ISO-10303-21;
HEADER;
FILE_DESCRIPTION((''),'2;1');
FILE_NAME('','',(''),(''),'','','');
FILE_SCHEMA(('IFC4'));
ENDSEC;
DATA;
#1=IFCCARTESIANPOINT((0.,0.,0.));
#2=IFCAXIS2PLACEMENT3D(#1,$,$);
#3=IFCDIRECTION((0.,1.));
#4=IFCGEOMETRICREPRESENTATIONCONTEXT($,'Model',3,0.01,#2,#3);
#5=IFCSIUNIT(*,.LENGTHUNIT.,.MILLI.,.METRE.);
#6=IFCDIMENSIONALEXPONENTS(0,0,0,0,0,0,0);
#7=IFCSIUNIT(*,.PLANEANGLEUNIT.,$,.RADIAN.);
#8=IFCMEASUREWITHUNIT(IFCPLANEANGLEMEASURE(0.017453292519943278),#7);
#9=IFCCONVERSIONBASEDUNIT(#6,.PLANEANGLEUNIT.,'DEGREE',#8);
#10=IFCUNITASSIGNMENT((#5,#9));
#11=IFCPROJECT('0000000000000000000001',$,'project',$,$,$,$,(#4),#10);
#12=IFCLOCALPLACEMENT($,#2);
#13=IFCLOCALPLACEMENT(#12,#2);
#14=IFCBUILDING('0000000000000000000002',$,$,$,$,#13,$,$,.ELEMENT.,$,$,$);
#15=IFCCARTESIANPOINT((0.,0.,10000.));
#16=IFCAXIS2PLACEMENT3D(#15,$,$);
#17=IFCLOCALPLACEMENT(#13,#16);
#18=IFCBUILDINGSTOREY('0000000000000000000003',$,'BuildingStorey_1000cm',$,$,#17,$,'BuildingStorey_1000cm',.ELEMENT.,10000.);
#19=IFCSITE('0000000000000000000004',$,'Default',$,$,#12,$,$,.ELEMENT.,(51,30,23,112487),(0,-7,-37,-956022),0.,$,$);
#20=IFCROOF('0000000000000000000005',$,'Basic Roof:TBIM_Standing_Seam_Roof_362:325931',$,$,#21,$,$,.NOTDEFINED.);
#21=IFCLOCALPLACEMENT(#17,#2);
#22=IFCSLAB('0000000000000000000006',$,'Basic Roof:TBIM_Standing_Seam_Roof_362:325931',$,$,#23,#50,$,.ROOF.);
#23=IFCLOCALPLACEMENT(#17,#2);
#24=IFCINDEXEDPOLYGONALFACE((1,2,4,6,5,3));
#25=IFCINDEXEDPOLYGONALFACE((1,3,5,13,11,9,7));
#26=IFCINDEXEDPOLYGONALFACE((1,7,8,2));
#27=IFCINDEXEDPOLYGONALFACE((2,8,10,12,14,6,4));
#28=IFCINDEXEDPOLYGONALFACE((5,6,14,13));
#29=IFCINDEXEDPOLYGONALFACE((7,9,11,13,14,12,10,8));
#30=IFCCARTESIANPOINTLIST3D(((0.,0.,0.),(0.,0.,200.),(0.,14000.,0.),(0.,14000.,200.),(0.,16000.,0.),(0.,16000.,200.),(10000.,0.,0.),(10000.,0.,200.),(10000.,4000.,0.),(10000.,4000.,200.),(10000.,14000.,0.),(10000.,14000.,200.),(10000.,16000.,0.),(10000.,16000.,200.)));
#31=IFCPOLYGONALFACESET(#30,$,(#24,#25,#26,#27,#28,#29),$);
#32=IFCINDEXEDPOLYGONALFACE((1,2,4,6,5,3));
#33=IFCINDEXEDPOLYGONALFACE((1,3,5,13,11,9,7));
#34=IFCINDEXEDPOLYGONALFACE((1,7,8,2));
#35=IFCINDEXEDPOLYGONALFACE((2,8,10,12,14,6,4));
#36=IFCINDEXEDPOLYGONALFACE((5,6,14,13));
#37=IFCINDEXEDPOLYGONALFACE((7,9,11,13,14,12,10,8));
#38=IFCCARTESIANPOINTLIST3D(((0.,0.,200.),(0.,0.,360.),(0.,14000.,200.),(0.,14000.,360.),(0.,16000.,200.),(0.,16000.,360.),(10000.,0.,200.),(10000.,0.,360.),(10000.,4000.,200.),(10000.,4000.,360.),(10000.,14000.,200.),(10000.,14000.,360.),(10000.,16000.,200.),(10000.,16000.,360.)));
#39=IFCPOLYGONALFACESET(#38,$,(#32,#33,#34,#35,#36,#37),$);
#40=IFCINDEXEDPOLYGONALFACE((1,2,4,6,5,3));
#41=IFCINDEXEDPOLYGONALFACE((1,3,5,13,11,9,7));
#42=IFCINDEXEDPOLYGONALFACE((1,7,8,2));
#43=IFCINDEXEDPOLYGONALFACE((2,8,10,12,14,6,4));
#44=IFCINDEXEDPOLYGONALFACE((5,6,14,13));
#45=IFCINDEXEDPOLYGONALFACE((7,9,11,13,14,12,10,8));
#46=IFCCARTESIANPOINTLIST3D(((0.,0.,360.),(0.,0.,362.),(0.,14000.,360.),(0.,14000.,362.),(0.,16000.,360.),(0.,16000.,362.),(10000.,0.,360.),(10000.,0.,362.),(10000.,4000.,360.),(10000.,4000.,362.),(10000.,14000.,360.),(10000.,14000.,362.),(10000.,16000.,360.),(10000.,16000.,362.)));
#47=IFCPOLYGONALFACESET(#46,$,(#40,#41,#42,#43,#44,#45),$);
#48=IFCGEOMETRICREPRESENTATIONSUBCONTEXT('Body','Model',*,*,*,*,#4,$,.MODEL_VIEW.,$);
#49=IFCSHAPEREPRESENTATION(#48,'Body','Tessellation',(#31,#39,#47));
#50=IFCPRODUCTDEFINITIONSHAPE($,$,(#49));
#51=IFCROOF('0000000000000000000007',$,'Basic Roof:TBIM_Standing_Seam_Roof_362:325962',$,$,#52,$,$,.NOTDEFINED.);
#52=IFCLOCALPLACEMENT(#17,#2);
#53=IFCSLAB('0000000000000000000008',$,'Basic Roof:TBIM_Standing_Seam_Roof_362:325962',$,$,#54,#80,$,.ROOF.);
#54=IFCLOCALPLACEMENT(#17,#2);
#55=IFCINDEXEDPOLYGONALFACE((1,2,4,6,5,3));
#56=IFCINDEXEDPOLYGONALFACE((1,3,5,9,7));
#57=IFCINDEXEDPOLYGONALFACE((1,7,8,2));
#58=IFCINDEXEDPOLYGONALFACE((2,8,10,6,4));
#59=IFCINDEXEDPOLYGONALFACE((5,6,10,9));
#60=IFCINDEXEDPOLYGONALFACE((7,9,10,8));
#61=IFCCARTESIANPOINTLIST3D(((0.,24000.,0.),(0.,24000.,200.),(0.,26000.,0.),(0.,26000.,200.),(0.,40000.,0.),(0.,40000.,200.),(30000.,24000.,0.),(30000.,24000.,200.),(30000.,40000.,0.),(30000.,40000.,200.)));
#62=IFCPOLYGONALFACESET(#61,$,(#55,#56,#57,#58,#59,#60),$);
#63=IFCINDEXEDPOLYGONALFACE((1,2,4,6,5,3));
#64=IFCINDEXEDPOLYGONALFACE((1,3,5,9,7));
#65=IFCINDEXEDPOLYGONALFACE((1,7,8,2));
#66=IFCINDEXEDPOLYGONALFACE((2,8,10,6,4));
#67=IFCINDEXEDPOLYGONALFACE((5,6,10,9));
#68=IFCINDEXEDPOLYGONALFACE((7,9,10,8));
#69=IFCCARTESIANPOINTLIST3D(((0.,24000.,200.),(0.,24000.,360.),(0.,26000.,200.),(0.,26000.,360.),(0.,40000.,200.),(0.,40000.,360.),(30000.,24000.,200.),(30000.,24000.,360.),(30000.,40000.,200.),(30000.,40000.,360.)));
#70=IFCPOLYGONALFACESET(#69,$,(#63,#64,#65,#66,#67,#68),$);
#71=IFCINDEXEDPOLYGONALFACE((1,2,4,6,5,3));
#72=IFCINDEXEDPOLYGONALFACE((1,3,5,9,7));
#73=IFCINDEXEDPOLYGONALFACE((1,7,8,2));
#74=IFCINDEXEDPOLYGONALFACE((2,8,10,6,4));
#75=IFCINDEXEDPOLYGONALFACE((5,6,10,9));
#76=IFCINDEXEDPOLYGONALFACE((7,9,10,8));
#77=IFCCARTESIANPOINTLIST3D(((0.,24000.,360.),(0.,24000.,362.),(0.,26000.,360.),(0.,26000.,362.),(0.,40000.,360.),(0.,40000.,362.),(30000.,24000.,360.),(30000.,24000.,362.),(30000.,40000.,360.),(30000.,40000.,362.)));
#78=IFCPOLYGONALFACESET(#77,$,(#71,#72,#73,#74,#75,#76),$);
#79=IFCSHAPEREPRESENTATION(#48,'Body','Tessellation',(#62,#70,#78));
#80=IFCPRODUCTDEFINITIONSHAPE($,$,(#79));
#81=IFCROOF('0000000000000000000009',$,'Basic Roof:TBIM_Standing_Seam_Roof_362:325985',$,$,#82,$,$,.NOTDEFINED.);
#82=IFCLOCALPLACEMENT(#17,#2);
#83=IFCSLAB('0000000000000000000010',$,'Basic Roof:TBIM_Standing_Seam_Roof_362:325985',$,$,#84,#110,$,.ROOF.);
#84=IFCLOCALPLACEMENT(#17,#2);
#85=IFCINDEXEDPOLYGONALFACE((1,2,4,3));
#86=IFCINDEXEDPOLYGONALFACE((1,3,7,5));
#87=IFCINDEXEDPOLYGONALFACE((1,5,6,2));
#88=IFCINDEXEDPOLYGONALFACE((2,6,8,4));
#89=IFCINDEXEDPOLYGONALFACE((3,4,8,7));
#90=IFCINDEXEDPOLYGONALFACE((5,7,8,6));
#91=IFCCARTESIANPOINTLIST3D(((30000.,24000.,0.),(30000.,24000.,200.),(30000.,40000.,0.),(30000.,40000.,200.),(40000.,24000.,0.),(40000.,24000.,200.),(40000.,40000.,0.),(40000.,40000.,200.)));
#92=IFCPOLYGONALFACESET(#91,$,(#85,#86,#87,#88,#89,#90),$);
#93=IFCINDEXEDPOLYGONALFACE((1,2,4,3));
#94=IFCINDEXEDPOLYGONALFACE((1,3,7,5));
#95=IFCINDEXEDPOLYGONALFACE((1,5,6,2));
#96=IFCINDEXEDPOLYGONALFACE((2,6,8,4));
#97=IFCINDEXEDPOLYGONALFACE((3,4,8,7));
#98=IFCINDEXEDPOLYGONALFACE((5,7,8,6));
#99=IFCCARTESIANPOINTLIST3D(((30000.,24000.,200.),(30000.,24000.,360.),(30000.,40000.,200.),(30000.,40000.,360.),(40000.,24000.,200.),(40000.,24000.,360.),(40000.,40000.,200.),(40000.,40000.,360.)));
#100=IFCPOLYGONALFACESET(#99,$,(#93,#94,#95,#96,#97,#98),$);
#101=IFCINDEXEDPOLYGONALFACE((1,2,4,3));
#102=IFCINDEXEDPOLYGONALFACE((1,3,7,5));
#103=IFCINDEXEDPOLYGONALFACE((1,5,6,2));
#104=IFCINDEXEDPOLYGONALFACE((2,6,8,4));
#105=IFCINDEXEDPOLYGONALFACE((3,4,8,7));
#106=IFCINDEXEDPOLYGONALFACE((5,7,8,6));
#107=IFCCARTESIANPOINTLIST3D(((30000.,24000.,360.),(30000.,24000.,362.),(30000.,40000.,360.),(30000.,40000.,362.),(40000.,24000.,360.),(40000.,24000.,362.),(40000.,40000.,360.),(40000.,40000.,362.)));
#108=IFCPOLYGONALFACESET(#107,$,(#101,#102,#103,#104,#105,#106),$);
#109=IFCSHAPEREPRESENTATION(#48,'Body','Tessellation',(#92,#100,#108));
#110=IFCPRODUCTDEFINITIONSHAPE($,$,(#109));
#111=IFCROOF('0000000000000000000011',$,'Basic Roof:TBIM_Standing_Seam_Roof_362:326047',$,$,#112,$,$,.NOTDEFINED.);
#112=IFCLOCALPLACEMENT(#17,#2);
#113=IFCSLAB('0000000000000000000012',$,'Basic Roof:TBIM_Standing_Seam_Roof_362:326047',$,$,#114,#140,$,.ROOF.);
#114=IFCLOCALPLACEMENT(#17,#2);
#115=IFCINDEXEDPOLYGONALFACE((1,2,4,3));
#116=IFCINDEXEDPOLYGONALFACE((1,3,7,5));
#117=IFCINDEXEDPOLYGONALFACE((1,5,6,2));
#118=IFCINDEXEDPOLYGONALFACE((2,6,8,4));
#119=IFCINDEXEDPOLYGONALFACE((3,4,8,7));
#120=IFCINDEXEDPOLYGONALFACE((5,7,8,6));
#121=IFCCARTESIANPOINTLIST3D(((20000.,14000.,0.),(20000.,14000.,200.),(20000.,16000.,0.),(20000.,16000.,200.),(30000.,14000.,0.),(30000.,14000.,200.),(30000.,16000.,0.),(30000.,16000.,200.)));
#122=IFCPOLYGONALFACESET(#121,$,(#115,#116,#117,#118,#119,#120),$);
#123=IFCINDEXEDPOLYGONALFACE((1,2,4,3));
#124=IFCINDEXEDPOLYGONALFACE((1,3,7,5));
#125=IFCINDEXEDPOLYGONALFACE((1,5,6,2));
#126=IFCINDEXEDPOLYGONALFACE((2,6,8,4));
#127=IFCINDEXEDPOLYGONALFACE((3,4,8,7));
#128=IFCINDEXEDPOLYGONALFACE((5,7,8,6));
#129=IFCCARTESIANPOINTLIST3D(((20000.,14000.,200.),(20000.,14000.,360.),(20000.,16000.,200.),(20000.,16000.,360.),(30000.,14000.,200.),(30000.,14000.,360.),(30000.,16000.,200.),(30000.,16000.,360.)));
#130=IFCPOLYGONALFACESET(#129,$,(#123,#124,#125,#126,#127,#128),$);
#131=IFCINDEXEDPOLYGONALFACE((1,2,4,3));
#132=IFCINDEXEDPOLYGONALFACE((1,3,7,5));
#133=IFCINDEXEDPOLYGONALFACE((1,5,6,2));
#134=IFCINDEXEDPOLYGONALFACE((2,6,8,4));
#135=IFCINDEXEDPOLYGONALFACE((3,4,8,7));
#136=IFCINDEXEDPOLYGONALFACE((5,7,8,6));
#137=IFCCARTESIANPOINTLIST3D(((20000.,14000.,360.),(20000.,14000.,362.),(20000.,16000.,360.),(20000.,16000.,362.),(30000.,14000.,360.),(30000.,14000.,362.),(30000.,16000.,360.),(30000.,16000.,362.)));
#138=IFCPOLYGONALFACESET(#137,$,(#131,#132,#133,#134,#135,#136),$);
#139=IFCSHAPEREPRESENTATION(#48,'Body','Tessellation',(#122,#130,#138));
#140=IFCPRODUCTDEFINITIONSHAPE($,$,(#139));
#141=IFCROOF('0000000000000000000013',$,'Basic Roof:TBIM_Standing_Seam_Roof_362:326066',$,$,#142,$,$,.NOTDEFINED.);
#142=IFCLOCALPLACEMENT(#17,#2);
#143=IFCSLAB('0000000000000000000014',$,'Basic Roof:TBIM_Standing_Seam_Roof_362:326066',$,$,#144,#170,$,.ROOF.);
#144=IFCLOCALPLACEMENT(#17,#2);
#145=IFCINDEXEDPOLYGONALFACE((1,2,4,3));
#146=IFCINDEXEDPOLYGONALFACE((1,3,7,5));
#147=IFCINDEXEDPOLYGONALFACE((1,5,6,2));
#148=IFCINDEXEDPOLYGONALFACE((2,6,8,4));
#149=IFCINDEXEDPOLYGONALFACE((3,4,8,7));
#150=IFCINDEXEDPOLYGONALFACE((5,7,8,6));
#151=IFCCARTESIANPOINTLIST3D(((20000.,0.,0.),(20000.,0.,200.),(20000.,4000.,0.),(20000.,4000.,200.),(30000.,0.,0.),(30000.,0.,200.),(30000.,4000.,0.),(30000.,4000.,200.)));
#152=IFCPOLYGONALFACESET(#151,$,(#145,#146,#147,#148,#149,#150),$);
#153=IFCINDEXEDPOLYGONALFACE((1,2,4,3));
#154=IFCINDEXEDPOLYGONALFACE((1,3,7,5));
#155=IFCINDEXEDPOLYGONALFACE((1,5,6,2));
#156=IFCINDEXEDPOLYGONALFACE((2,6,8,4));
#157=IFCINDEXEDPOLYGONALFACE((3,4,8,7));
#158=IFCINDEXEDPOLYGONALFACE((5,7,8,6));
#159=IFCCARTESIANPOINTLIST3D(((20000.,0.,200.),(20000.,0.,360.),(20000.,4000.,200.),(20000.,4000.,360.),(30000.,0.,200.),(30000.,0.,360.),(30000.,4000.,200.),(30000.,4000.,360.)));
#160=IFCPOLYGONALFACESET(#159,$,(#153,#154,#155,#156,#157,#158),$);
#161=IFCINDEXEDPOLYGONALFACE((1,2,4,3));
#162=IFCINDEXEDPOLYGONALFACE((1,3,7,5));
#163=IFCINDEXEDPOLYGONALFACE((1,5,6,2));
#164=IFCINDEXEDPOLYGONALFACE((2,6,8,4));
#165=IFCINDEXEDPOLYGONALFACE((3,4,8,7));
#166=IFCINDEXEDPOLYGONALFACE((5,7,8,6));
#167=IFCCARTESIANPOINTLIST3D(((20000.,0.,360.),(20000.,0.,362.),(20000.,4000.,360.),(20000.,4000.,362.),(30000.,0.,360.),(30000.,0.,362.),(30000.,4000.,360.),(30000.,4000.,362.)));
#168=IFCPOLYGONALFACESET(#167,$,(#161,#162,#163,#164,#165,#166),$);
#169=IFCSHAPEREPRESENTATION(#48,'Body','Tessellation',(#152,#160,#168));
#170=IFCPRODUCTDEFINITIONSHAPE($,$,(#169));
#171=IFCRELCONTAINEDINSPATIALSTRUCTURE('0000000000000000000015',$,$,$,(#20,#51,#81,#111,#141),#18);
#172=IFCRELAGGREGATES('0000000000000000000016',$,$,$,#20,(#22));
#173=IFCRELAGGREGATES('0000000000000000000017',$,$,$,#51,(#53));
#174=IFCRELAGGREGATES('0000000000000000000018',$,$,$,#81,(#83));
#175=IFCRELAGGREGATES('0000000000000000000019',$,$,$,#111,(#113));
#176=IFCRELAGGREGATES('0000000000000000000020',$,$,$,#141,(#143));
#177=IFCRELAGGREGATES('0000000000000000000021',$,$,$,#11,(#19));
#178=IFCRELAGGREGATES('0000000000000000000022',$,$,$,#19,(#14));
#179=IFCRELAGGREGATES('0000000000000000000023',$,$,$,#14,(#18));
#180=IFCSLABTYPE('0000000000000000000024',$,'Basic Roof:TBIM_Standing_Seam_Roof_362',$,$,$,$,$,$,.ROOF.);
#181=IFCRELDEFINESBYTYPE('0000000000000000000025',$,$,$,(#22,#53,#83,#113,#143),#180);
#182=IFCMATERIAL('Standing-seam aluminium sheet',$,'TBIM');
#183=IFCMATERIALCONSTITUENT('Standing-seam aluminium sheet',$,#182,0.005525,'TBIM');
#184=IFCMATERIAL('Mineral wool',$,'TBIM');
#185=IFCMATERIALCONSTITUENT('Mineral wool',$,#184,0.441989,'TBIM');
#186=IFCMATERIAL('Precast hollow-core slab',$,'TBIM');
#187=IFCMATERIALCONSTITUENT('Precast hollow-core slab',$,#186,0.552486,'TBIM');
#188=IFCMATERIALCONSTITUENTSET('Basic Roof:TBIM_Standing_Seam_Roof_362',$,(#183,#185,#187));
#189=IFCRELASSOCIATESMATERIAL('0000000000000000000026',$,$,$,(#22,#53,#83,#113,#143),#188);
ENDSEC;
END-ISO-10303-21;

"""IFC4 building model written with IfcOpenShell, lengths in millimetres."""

from ifc_helpers import new_model, entity, si_unit, converted_unit, direction, frame, origin, place, context, subcontext, project, spatial, indexed_curve, outline, extrude, material, constituent, constituent_set, type_object, element, aggregate, save


model = new_model("IFC4")

# Units and contexts
model_context = context("Model", 3, precision=0.01, world=origin(), true_north=direction((0.0, 1.0)))
body_context = subcontext(model_context, "Body", "Model", "MODEL_VIEW")
ifc_project = project(units=[si_unit("LENGTHUNIT", "METRE", prefix="MILLI"), converted_unit("PLANEANGLEUNIT", "DEGREE", entity("IfcPlaneAngleMeasure", 0.017453292519943278), si_unit("PLANEANGLEUNIT", "RADIAN"), dimensions=[0, 0, 0, 0, 0, 0, 0])], contexts=[model_context])

# Site, building, storey
site_placement = place(None, origin())
site = spatial("IfcSite", under=ifc_project, at=site_placement, Name="Default", CompositionType="ELEMENT", RefLatitude=(51, 30, 23, 112487), RefLongitude=(0, -7, -37, -956022), RefElevation=0.0)
building_placement = place(site_placement, origin())
building = spatial("IfcBuilding", under=site, at=building_placement, CompositionType="ELEMENT")
storey_placement = place(building_placement, frame((0.0, 0.0, 10000.0)))
storey = spatial("IfcBuildingStorey", under=building, at=storey_placement, Name="BuildingStorey_1000cm", LongName="BuildingStorey_1000cm", CompositionType="ELEMENT", Elevation=10000.0)

# Shared definitions
ifc_material_1 = material(Name="Precast hollow-core slab", Category="TBIM")

# Roofs, slabs
ifc_material_2 = material(Name="Standing-seam aluminium sheet", Category="TBIM")
ifc_constituent_1 = constituent(ifc_material_2, Name="Standing-seam aluminium sheet", Category="TBIM", fraction=0.005525)
ifc_material_3 = material(Name="Mineral wool", Category="TBIM")
ifc_constituent_2 = constituent(ifc_material_3, Name="Mineral wool", Category="TBIM", fraction=0.441989)
ifc_constituent_3 = constituent(ifc_material_1, Name="Precast hollow-core slab", Category="TBIM", fraction=0.552486)
ifc_constituent_set_1 = constituent_set(constituents=[ifc_constituent_1, ifc_constituent_2, ifc_constituent_3], Name="Basic Roof:TBIM_Standing_Seam_Roof_362")
slab_type_1 = type_object("IfcSlabType", Name="Basic Roof:TBIM_Standing_Seam_Roof_362", PredefinedType="ROOF")
roof_1_placement = place(storey_placement, origin())
roof_1 = element("IfcRoof", 1, at=roof_1_placement, inside=storey, Name="Basic Roof:TBIM_Standing_Seam_Roof_362:325931", PredefinedType="NOTDEFINED")
slab_1_placement = place(roof_1_placement, origin())
slab_1 = element("IfcSlab", 2, at=slab_1_placement, type_object=slab_type_1, material=ifc_constituent_set_1, Name="Basic Roof:TBIM_Standing_Seam_Roof_362:325931", PredefinedType="ROOF", context=body_context, shape_type="SweptSolid", body=[
    extrude(outline(indexed_curve([(-5000.0, 8000.0), (-5000.0, 6000.0), (-5000.0, -8000.0), (5000.0, -8000.0), (5000.0, -4000.0), (5000.0, 6000.0), (5000.0, 8000.0), (-5000.0, 8000.0)], self_intersect=False)), frame((5000.0, 8000.0, 0.0)), (0.0, 0.0, 1.0), 200.0),
    extrude(outline(indexed_curve([(-5000.0, 8000.0), (-5000.0, 6000.0), (-5000.0, -8000.0), (5000.0, -8000.0), (5000.0, -4000.0), (5000.0, 6000.0), (5000.0, 8000.0), (-5000.0, 8000.0)], self_intersect=False)), frame((5000.0, 8000.0, 200.0)), (0.0, 0.0, 1.0), 160.0),
    extrude(outline(indexed_curve([(-5000.0, 8000.0), (-5000.0, 6000.0), (-5000.0, -8000.0), (5000.0, -8000.0), (5000.0, -4000.0), (5000.0, 6000.0), (5000.0, 8000.0), (-5000.0, 8000.0)], self_intersect=False)), frame((5000.0, 8000.0, 360.0)), (0.0, 0.0, 1.0), 2.0),
])
aggregate(roof_1, [slab_1])
roof_2_placement = place(storey_placement, frame((0.0, 24000.0, 0.0)))
roof_2 = element("IfcRoof", 3, at=roof_2_placement, inside=storey, Name="Basic Roof:TBIM_Standing_Seam_Roof_362:325962", PredefinedType="NOTDEFINED")
slab_2_placement = place(roof_2_placement, origin())
slab_2 = element("IfcSlab", 4, at=slab_2_placement, type_object=slab_type_1, material=ifc_constituent_set_1, Name="Basic Roof:TBIM_Standing_Seam_Roof_362:325962", PredefinedType="ROOF", context=body_context, shape_type="SweptSolid", body=[
    extrude(outline(indexed_curve([(-15000.0, 8000.0), (-15000.0, -6000.0), (-15000.0, -8000.0), (15000.0, -8000.0), (15000.0, 8000.0), (-15000.0, 8000.0)], self_intersect=False)), frame((15000.0, 8000.0, 0.0)), (0.0, 0.0, 1.0), 200.0),
    extrude(outline(indexed_curve([(-15000.0, 8000.0), (-15000.0, -6000.0), (-15000.0, -8000.0), (15000.0, -8000.0), (15000.0, 8000.0), (-15000.0, 8000.0)], self_intersect=False)), frame((15000.0, 8000.0, 200.0)), (0.0, 0.0, 1.0), 160.0),
    extrude(outline(indexed_curve([(-15000.0, 8000.0), (-15000.0, -6000.0), (-15000.0, -8000.0), (15000.0, -8000.0), (15000.0, 8000.0), (-15000.0, 8000.0)], self_intersect=False)), frame((15000.0, 8000.0, 360.0)), (0.0, 0.0, 1.0), 2.0),
])
aggregate(roof_2, [slab_2])
roof_3_placement = place(storey_placement, frame((30000.0, 24000.0, 0.0)))
roof_3 = element("IfcRoof", 5, at=roof_3_placement, inside=storey, Name="Basic Roof:TBIM_Standing_Seam_Roof_362:325985", PredefinedType="NOTDEFINED")
slab_3_placement = place(roof_3_placement, origin())
slab_3 = element("IfcSlab", 6, at=slab_3_placement, type_object=slab_type_1, material=ifc_constituent_set_1, Name="Basic Roof:TBIM_Standing_Seam_Roof_362:325985", PredefinedType="ROOF", context=body_context, shape_type="SweptSolid", body=[
    extrude(outline(indexed_curve([(-5000.0, 8000.0), (-5000.0, -8000.0), (5000.0, -8000.0), (5000.0, 8000.0), (-5000.0, 8000.0)], self_intersect=False)), frame((5000.0, 8000.0, 0.0)), (0.0, 0.0, 1.0), 200.0),
    extrude(outline(indexed_curve([(-5000.0, 8000.0), (-5000.0, -8000.0), (5000.0, -8000.0), (5000.0, 8000.0), (-5000.0, 8000.0)], self_intersect=False)), frame((5000.0, 8000.0, 200.0)), (0.0, 0.0, 1.0), 160.0),
    extrude(outline(indexed_curve([(-5000.0, 8000.0), (-5000.0, -8000.0), (5000.0, -8000.0), (5000.0, 8000.0), (-5000.0, 8000.0)], self_intersect=False)), frame((5000.0, 8000.0, 360.0)), (0.0, 0.0, 1.0), 2.0),
])
aggregate(roof_3, [slab_3])
roof_4_placement = place(storey_placement, frame((20000.0, 14000.0, 0.0)))
roof_4 = element("IfcRoof", 7, at=roof_4_placement, inside=storey, Name="Basic Roof:TBIM_Standing_Seam_Roof_362:326047", PredefinedType="NOTDEFINED")
slab_4_placement = place(roof_4_placement, origin())
slab_4 = element("IfcSlab", 8, at=slab_4_placement, type_object=slab_type_1, material=ifc_constituent_set_1, Name="Basic Roof:TBIM_Standing_Seam_Roof_362:326047", PredefinedType="ROOF", context=body_context, shape_type="SweptSolid", body=[
    extrude(outline(indexed_curve([(-5000.0, 1000.0), (-5000.0, -1000.0), (5000.0, -1000.0), (5000.0, 1000.0), (-5000.0, 1000.0)], self_intersect=False)), frame((5000.0, 1000.0, 0.0)), (0.0, 0.0, 1.0), 200.0),
    extrude(outline(indexed_curve([(-5000.0, 1000.0), (-5000.0, -1000.0), (5000.0, -1000.0), (5000.0, 1000.0), (-5000.0, 1000.0)], self_intersect=False)), frame((5000.0, 1000.0, 200.0)), (0.0, 0.0, 1.0), 160.0),
    extrude(outline(indexed_curve([(-5000.0, 1000.0), (-5000.0, -1000.0), (5000.0, -1000.0), (5000.0, 1000.0), (-5000.0, 1000.0)], self_intersect=False)), frame((5000.0, 1000.0, 360.0)), (0.0, 0.0, 1.0), 2.0),
])
aggregate(roof_4, [slab_4])
roof_5_placement = place(storey_placement, frame((20000.0, 0.0, 0.0)))
roof_5 = element("IfcRoof", 9, at=roof_5_placement, inside=storey, Name="Basic Roof:TBIM_Standing_Seam_Roof_362:326066", PredefinedType="NOTDEFINED")
slab_5_placement = place(roof_5_placement, origin())
slab_5 = element("IfcSlab", 10, at=slab_5_placement, type_object=slab_type_1, material=ifc_constituent_set_1, Name="Basic Roof:TBIM_Standing_Seam_Roof_362:326066", PredefinedType="ROOF", context=body_context, shape_type="SweptSolid", body=[
    extrude(outline(indexed_curve([(-5000.0, 2000.0), (-5000.0, -2000.0), (5000.0, -2000.0), (5000.0, 2000.0), (-5000.0, 2000.0)], self_intersect=False)), frame((5000.0, 2000.0, 0.0)), (0.0, 0.0, 1.0), 200.0),
    extrude(outline(indexed_curve([(-5000.0, 2000.0), (-5000.0, -2000.0), (5000.0, -2000.0), (5000.0, 2000.0), (-5000.0, 2000.0)], self_intersect=False)), frame((5000.0, 2000.0, 200.0)), (0.0, 0.0, 1.0), 160.0),
    extrude(outline(indexed_curve([(-5000.0, 2000.0), (-5000.0, -2000.0), (5000.0, -2000.0), (5000.0, 2000.0), (-5000.0, 2000.0)], self_intersect=False)), frame((5000.0, 2000.0, 360.0)), (0.0, 0.0, 1.0), 2.0),
])
aggregate(roof_5, [slab_5])

save(model, "model.ifc")
